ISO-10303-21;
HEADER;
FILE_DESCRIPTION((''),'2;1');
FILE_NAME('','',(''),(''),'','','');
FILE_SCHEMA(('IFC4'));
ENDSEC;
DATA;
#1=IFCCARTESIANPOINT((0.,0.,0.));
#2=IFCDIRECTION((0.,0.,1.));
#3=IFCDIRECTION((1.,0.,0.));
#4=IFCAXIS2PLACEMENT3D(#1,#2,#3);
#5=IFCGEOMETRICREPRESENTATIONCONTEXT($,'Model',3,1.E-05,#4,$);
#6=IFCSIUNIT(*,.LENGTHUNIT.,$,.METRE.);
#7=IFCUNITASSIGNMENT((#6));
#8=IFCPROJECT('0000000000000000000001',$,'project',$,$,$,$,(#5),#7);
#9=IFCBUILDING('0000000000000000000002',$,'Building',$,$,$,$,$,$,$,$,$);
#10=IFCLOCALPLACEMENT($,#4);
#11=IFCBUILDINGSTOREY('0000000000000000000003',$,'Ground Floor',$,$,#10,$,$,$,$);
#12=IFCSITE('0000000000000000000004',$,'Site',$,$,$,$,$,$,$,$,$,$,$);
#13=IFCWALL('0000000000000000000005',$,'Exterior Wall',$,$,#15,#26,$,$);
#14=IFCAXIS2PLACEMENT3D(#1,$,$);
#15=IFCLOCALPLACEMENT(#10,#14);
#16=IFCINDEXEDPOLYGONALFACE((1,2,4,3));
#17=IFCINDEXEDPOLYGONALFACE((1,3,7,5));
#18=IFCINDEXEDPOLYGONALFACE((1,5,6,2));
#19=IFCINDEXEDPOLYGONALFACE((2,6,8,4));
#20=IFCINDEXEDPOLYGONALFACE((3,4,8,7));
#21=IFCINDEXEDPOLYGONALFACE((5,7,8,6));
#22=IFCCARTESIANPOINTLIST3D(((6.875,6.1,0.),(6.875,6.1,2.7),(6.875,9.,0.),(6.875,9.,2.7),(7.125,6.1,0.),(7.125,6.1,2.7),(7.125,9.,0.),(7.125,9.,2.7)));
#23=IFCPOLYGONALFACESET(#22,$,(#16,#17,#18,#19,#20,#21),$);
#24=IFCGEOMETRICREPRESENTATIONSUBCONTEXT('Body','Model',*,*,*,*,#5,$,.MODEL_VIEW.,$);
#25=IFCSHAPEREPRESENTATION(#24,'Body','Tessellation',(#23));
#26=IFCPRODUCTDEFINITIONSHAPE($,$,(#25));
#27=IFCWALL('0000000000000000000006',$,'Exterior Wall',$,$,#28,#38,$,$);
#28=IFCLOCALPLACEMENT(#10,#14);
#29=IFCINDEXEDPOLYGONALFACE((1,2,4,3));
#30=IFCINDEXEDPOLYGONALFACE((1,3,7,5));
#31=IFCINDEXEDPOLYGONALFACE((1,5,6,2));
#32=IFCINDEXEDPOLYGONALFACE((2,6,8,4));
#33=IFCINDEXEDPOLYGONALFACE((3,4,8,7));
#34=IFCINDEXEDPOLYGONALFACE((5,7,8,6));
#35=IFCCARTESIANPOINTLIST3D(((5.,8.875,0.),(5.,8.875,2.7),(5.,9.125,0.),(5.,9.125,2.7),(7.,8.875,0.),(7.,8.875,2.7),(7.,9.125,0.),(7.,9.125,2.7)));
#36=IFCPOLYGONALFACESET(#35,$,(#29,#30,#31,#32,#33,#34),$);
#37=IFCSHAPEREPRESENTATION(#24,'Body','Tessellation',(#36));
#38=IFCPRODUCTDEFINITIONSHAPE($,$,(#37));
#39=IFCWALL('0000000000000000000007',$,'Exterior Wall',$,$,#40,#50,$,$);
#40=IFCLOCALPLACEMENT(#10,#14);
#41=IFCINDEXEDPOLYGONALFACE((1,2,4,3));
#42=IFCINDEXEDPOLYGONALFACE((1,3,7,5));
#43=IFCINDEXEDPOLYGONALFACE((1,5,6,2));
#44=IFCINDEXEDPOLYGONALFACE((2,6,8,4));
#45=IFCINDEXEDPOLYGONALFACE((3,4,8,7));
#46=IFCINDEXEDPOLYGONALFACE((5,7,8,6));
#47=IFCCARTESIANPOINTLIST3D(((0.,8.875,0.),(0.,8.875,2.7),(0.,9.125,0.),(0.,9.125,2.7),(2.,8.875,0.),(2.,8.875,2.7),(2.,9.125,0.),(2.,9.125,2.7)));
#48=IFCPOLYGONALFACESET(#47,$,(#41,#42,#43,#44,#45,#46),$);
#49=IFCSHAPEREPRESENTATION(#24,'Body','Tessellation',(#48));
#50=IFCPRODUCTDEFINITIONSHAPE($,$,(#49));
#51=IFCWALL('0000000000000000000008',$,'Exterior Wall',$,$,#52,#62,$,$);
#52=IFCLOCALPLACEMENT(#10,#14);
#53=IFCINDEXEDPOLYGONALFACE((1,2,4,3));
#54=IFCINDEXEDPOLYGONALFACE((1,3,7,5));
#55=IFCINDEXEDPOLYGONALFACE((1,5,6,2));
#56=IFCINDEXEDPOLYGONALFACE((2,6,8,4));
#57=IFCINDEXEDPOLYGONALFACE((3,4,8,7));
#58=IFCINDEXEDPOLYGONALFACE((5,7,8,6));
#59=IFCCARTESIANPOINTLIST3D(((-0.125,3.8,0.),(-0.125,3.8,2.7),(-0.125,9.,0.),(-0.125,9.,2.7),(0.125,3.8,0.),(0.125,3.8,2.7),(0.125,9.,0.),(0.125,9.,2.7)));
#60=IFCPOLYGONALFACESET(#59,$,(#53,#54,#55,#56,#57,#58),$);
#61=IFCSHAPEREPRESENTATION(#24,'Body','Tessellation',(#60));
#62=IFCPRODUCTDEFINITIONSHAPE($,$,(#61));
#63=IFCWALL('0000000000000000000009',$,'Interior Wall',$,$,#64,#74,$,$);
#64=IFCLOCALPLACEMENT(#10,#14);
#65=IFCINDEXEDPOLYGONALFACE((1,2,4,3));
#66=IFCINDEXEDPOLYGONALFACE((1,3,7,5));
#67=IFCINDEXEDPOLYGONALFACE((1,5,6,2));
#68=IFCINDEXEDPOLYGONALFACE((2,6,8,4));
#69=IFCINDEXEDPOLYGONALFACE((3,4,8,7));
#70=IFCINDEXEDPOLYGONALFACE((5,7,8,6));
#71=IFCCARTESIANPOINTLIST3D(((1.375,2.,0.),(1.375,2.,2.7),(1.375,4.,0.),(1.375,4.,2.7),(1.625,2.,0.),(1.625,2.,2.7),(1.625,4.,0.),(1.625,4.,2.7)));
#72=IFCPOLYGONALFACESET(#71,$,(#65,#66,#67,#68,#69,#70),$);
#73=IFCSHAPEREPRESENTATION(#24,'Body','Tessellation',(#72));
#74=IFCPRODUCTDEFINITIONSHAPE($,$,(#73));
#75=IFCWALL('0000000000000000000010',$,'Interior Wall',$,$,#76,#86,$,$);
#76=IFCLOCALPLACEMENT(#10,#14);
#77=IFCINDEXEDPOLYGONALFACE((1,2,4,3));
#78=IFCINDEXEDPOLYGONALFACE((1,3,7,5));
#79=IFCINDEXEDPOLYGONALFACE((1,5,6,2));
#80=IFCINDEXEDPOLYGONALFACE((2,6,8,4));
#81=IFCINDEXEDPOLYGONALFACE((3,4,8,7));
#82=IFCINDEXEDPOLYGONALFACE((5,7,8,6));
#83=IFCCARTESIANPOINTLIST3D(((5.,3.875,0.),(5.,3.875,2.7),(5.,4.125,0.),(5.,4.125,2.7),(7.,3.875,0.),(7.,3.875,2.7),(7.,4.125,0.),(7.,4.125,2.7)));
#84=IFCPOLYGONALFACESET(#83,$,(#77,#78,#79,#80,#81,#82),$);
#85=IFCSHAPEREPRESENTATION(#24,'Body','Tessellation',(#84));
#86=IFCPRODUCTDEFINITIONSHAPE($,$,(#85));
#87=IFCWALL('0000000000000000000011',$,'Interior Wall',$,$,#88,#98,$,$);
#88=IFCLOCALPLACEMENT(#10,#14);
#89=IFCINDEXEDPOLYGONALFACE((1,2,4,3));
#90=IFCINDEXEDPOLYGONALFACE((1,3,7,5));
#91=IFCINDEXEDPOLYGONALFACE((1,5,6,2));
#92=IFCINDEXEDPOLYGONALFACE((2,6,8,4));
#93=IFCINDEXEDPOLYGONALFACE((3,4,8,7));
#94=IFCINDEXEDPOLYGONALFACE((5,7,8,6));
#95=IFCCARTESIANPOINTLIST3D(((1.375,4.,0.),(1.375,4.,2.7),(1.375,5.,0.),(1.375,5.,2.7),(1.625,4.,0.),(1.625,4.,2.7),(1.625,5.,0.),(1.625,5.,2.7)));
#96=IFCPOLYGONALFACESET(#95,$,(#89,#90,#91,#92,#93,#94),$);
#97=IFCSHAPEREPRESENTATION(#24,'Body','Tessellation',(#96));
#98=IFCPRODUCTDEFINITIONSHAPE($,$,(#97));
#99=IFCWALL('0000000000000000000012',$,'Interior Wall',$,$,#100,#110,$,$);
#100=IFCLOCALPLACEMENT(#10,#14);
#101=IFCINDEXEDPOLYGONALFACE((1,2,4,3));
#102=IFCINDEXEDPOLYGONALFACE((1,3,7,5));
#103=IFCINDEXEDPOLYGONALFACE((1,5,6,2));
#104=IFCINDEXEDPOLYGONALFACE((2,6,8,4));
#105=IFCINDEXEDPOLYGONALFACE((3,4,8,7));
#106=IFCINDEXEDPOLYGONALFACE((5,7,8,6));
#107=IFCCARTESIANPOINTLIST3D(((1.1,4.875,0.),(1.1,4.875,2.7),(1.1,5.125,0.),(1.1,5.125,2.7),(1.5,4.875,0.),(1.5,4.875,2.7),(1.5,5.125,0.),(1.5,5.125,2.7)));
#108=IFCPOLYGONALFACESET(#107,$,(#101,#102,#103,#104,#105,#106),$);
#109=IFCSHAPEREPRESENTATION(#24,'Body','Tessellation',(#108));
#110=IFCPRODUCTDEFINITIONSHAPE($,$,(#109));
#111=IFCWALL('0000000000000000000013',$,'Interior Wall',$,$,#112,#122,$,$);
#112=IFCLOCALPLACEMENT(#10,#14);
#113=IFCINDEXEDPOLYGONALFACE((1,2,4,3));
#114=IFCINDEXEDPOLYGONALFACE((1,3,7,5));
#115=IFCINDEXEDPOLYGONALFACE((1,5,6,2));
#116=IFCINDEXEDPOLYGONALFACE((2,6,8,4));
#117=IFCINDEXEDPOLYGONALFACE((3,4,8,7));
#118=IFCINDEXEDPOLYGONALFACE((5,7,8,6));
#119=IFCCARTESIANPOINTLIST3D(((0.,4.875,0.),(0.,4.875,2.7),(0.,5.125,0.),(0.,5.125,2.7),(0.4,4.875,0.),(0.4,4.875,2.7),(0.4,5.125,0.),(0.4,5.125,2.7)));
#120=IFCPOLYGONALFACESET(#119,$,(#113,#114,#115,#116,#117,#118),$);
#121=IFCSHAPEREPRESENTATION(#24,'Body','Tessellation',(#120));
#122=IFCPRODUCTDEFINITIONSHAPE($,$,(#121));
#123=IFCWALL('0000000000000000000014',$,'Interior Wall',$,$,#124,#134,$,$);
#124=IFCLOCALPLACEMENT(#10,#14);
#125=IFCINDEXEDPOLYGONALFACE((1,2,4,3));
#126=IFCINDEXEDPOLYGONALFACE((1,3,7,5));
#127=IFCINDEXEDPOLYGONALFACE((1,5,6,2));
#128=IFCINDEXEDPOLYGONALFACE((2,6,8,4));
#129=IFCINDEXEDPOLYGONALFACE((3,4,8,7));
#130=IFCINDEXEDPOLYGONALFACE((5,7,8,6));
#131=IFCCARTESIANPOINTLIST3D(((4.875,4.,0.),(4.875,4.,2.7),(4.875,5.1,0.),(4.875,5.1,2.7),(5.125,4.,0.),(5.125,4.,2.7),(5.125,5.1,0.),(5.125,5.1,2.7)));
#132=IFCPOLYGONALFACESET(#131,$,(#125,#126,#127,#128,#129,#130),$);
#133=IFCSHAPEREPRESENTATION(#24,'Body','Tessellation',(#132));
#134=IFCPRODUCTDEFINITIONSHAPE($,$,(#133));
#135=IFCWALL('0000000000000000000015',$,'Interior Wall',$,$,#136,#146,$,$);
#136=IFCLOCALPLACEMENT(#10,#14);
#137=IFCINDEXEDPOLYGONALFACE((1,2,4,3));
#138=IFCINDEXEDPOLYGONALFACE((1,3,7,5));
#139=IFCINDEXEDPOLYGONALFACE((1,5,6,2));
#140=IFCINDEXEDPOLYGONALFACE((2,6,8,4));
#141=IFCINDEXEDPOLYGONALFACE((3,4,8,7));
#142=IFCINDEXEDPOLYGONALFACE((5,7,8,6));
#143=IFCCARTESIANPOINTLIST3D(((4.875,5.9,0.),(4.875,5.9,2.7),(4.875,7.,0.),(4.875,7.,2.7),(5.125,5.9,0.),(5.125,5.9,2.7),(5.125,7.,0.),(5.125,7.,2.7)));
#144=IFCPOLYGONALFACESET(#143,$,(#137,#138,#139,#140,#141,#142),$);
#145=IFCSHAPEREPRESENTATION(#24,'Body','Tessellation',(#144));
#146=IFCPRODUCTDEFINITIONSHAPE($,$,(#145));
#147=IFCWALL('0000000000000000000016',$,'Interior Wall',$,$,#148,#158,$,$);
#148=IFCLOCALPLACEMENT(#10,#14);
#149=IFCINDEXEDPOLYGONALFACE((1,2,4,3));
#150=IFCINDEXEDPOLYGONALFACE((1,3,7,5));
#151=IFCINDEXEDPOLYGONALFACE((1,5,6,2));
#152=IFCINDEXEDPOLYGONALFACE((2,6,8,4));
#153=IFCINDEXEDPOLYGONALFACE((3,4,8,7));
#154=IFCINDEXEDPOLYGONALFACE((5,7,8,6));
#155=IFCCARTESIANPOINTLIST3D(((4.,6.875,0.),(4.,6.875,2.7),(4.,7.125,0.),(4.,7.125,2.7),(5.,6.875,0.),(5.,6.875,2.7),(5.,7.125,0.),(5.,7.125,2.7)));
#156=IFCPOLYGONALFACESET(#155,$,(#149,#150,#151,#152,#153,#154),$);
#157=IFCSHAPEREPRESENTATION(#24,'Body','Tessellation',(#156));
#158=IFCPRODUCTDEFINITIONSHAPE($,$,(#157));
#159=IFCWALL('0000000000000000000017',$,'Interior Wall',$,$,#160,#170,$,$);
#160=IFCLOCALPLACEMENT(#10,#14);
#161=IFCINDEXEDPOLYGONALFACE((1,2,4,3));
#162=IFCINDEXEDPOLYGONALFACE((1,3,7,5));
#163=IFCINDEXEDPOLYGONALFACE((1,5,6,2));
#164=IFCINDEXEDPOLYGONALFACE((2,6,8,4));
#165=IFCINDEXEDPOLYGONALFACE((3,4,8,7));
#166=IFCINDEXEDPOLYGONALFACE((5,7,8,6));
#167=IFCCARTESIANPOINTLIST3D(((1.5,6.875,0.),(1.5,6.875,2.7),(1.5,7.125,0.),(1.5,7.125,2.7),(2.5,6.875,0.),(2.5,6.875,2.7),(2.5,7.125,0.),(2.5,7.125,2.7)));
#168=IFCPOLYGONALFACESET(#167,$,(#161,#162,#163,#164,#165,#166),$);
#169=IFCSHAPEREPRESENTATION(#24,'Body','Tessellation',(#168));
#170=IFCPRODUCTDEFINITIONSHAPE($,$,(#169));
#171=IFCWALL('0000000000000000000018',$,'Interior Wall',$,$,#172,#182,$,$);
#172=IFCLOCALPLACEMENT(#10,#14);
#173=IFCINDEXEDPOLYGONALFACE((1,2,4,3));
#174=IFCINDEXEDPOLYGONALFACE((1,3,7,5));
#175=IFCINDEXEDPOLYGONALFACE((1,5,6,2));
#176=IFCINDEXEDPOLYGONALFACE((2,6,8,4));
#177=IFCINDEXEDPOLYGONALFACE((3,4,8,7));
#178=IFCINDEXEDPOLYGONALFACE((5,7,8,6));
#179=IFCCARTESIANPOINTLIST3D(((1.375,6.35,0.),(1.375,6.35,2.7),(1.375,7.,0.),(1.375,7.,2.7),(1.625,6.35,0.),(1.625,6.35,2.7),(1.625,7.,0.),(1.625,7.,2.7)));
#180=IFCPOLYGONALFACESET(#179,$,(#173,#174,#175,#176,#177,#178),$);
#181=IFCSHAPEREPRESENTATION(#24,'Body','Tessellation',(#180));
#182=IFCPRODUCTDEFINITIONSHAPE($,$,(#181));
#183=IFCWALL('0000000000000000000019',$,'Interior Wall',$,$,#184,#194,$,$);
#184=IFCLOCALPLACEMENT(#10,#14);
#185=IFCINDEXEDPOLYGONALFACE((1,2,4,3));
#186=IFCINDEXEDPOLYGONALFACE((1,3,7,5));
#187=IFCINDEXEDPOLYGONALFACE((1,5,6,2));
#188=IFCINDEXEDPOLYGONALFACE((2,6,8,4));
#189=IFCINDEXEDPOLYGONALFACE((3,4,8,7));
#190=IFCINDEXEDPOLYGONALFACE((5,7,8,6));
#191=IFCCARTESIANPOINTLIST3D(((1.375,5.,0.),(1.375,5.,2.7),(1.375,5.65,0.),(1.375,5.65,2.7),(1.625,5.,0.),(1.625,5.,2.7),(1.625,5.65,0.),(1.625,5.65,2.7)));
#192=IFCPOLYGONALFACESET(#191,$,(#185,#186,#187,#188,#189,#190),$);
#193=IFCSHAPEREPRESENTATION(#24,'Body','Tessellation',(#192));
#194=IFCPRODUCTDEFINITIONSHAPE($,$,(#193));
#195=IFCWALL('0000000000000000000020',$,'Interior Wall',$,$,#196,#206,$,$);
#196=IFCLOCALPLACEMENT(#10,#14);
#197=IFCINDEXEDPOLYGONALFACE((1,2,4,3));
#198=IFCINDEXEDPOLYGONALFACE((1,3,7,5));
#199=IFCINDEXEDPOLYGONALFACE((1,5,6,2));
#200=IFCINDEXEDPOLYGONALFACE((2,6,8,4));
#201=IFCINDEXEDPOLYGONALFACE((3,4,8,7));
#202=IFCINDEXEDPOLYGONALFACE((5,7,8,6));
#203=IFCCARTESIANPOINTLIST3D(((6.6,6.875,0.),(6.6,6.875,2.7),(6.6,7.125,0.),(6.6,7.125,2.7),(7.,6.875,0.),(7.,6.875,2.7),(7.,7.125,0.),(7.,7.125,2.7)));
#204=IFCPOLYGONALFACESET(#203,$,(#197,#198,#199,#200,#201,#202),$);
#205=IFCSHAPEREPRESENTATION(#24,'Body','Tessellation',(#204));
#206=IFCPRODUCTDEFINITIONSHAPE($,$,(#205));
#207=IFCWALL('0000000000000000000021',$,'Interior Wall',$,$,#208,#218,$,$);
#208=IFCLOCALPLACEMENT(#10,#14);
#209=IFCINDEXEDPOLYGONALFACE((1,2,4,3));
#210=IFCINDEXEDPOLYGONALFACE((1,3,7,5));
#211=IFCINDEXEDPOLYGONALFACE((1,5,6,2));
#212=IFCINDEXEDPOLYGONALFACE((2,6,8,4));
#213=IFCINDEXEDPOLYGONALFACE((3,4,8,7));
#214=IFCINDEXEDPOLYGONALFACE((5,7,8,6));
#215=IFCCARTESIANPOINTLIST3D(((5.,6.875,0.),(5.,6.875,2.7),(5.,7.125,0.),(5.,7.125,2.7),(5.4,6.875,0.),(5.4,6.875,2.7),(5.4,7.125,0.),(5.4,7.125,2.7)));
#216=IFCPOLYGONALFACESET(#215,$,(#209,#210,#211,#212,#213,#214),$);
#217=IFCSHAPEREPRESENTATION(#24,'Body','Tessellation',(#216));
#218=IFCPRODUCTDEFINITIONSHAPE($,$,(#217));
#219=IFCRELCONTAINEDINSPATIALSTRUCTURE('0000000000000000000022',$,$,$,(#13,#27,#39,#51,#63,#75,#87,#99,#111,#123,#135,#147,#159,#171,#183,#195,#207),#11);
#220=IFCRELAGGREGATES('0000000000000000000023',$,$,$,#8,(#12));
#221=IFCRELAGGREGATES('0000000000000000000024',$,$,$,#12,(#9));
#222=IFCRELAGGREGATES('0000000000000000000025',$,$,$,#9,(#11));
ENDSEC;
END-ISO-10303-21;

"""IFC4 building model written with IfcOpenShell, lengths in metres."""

from ifc_helpers import new_model, si_unit, frame, origin_with_axes, place, context, subcontext, project, spatial, indexed_curve, outline, extrude, element, save


model = new_model("IFC4")

# Units and contexts
model_context = context("Model", 3, precision=1e-05, world=origin_with_axes())
body_context = subcontext(model_context, "Body", "Model", "MODEL_VIEW")
ifc_project = project(units=[si_unit("LENGTHUNIT", "METRE")], contexts=[model_context])

# Site, building, storey
site = spatial("IfcSite", under=ifc_project, Name="Site")
building = spatial("IfcBuilding", under=site, Name="Building")
storey_placement = place(None, origin_with_axes())
storey = spatial("IfcBuildingStorey", under=building, at=storey_placement, Name="Ground Floor")

# Walls
wall_1_placement = place(storey_placement, frame((7.0, 6.1, 0.0), z_axis=(0.0, 0.0, 1.0), x_axis=(0.0, 1.0, 0.0)))
element("IfcWall", 1, at=wall_1_placement, inside=storey, Name="Exterior Wall", context=body_context, shape_type="SweptSolid", body=[
    extrude(outline(indexed_curve([(0.0, 0.0), (0.0, 0.25), (2.9, 0.25), (2.9, 0.0), (0.0, 0.0)], self_intersect=False)), frame((0.0, -0.125, 0.0), z_axis=(0.0, 0.0, 1.0), x_axis=(1.0, 0.0, 0.0)), (0.0, 0.0, 1.0), 2.7),
])
for number, where, z_axis, x_axis, name in (
    (2, (7.0, 9.0, 0.0), (0.0, 0.0, 1.0), (-1.0, 0.0, 0.0), "Exterior Wall"),
    (3, (2.0, 9.0, 0.0), (0.0, 0.0, 1.0), (-1.0, 0.0, 0.0), "Exterior Wall"),
):
    element("IfcWall", number, at=place(storey_placement, frame(where, z_axis=z_axis, x_axis=x_axis)), inside=storey, Name=name, context=body_context, shape_type="SweptSolid", body=[
        extrude(outline(indexed_curve([(0.0, 0.0), (0.0, 0.25), (2.0, 0.25), (2.0, 0.0), (0.0, 0.0)], self_intersect=False)), frame((0.0, -0.125, 0.0), z_axis=(0.0, 0.0, 1.0), x_axis=(1.0, 0.0, 0.0)), (0.0, 0.0, 1.0), 2.7),
    ])
wall_2_placement = place(storey_placement, frame((0.0, 9.0, 0.0), z_axis=(0.0, 0.0, 1.0), x_axis=(0.0, -1.0, 0.0)))
element("IfcWall", 4, at=wall_2_placement, inside=storey, Name="Exterior Wall", context=body_context, shape_type="SweptSolid", body=[
    extrude(outline(indexed_curve([(0.0, 0.0), (0.0, 0.25), (5.2, 0.25), (5.2, 0.0), (0.0, 0.0)], self_intersect=False)), frame((0.0, -0.125, 0.0), z_axis=(0.0, 0.0, 1.0), x_axis=(1.0, 0.0, 0.0)), (0.0, 0.0, 1.0), 2.7),
])
for number, where, z_axis, x_axis, name in (
    (5, (1.5, 4.0, 0.0), (0.0, 0.0, 1.0), (0.0, -1.0, 0.0), "Interior Wall"),
    (6, (7.0, 4.0, 0.0), (0.0, 0.0, 1.0), (-1.0, 0.0, 0.0), "Interior Wall"),
):
    element("IfcWall", number, at=place(storey_placement, frame(where, z_axis=z_axis, x_axis=x_axis)), inside=storey, Name=name, context=body_context, shape_type="SweptSolid", body=[
        extrude(outline(indexed_curve([(0.0, 0.0), (0.0, 0.25), (2.0, 0.25), (2.0, 0.0), (0.0, 0.0)], self_intersect=False)), frame((0.0, -0.125, 0.0), z_axis=(0.0, 0.0, 1.0), x_axis=(1.0, 0.0, 0.0)), (0.0, 0.0, 1.0), 2.7),
    ])
wall_3_placement = place(storey_placement, frame((1.5, 4.0, 0.0), z_axis=(0.0, 0.0, 1.0), x_axis=(0.0, 1.0, 0.0)))
element("IfcWall", 7, at=wall_3_placement, inside=storey, Name="Interior Wall", context=body_context, shape_type="SweptSolid", body=[
    extrude(outline(indexed_curve([(0.0, 0.0), (0.0, 0.25), (1.0, 0.25), (1.0, 0.0), (0.0, 0.0)], self_intersect=False)), frame((0.0, -0.125, 0.0), z_axis=(0.0, 0.0, 1.0), x_axis=(1.0, 0.0, 0.0)), (0.0, 0.0, 1.0), 2.7),
])
for number, where, z_axis, x_axis, name in (
    (8, (1.5, 5.0, 0.0), (0.0, 0.0, 1.0), (-1.0, 0.0, 0.0), "Interior Wall"),
    (9, (0.4, 5.0, 0.0), (0.0, 0.0, 1.0), (-1.0, 0.0, 0.0), "Interior Wall"),
):
    element("IfcWall", number, at=place(storey_placement, frame(where, z_axis=z_axis, x_axis=x_axis)), inside=storey, Name=name, context=body_context, shape_type="SweptSolid", body=[
        extrude(outline(indexed_curve([(0.0, 0.0), (0.0, 0.25), (0.4, 0.25), (0.4, 0.0), (0.0, 0.0)], self_intersect=False)), frame((0.0, -0.125, 0.0), z_axis=(0.0, 0.0, 1.0), x_axis=(1.0, 0.0, 0.0)), (0.0, 0.0, 1.0), 2.7),
    ])
for number, where, z_axis, x_axis, name in (
    (10, (5.0, 4.0, 0.0), (0.0, 0.0, 1.0), (0.0, 1.0, 0.0), "Interior Wall"),
    (11, (5.0, 5.9, 0.0), (0.0, 0.0, 1.0), (0.0, 1.0, 0.0), "Interior Wall"),
):
    element("IfcWall", number, at=place(storey_placement, frame(where, z_axis=z_axis, x_axis=x_axis)), inside=storey, Name=name, context=body_context, shape_type="SweptSolid", body=[
        extrude(outline(indexed_curve([(0.0, 0.0), (0.0, 0.25), (1.1, 0.25), (1.1, 0.0), (0.0, 0.0)], self_intersect=False)), frame((0.0, -0.125, 0.0), z_axis=(0.0, 0.0, 1.0), x_axis=(1.0, 0.0, 0.0)), (0.0, 0.0, 1.0), 2.7),
    ])
for number, where, z_axis, x_axis, name in (
    (12, (5.0, 7.0, 0.0), (0.0, 0.0, 1.0), (-1.0, 0.0, 0.0), "Interior Wall"),
    (13, (2.5, 7.0, 0.0), (0.0, 0.0, 1.0), (-1.0, 0.0, 0.0), "Interior Wall"),
):
    element("IfcWall", number, at=place(storey_placement, frame(where, z_axis=z_axis, x_axis=x_axis)), inside=storey, Name=name, context=body_context, shape_type="SweptSolid", body=[
        extrude(outline(indexed_curve([(0.0, 0.0), (0.0, 0.25), (1.0, 0.25), (1.0, 0.0), (0.0, 0.0)], self_intersect=False)), frame((0.0, -0.125, 0.0), z_axis=(0.0, 0.0, 1.0), x_axis=(1.0, 0.0, 0.0)), (0.0, 0.0, 1.0), 2.7),
    ])
for number, where, z_axis, x_axis, name in (
    (14, (1.5, 7.0, 0.0), (0.0, 0.0, 1.0), (0.0, -1.0, 0.0), "Interior Wall"),
    (15, (1.5, 5.65, 0.0), (0.0, 0.0, 1.0), (0.0, -1.0, 0.0), "Interior Wall"),
):
    element("IfcWall", number, at=place(storey_placement, frame(where, z_axis=z_axis, x_axis=x_axis)), inside=storey, Name=name, context=body_context, shape_type="SweptSolid", body=[
        extrude(outline(indexed_curve([(0.0, 0.0), (0.0, 0.25), (0.65, 0.25), (0.65, 0.0), (0.0, 0.0)], self_intersect=False)), frame((0.0, -0.125, 0.0), z_axis=(0.0, 0.0, 1.0), x_axis=(1.0, 0.0, 0.0)), (0.0, 0.0, 1.0), 2.7),
    ])
for number, where, z_axis, x_axis, name in (
    (16, (7.0, 7.0, 0.0), (0.0, 0.0, 1.0), (-1.0, 0.0, 0.0), "Interior Wall"),
    (17, (5.4, 7.0, 0.0), (0.0, 0.0, 1.0), (-1.0, 0.0, 0.0), "Interior Wall"),
):
    element("IfcWall", number, at=place(storey_placement, frame(where, z_axis=z_axis, x_axis=x_axis)), inside=storey, Name=name, context=body_context, shape_type="SweptSolid", body=[
        extrude(outline(indexed_curve([(0.0, 0.0), (0.0, 0.25), (0.4, 0.25), (0.4, 0.0), (0.0, 0.0)], self_intersect=False)), frame((0.0, -0.125, 0.0), z_axis=(0.0, 0.0, 1.0), x_axis=(1.0, 0.0, 0.0)), (0.0, 0.0, 1.0), 2.7),
    ])

save(model, "model.ifc")
